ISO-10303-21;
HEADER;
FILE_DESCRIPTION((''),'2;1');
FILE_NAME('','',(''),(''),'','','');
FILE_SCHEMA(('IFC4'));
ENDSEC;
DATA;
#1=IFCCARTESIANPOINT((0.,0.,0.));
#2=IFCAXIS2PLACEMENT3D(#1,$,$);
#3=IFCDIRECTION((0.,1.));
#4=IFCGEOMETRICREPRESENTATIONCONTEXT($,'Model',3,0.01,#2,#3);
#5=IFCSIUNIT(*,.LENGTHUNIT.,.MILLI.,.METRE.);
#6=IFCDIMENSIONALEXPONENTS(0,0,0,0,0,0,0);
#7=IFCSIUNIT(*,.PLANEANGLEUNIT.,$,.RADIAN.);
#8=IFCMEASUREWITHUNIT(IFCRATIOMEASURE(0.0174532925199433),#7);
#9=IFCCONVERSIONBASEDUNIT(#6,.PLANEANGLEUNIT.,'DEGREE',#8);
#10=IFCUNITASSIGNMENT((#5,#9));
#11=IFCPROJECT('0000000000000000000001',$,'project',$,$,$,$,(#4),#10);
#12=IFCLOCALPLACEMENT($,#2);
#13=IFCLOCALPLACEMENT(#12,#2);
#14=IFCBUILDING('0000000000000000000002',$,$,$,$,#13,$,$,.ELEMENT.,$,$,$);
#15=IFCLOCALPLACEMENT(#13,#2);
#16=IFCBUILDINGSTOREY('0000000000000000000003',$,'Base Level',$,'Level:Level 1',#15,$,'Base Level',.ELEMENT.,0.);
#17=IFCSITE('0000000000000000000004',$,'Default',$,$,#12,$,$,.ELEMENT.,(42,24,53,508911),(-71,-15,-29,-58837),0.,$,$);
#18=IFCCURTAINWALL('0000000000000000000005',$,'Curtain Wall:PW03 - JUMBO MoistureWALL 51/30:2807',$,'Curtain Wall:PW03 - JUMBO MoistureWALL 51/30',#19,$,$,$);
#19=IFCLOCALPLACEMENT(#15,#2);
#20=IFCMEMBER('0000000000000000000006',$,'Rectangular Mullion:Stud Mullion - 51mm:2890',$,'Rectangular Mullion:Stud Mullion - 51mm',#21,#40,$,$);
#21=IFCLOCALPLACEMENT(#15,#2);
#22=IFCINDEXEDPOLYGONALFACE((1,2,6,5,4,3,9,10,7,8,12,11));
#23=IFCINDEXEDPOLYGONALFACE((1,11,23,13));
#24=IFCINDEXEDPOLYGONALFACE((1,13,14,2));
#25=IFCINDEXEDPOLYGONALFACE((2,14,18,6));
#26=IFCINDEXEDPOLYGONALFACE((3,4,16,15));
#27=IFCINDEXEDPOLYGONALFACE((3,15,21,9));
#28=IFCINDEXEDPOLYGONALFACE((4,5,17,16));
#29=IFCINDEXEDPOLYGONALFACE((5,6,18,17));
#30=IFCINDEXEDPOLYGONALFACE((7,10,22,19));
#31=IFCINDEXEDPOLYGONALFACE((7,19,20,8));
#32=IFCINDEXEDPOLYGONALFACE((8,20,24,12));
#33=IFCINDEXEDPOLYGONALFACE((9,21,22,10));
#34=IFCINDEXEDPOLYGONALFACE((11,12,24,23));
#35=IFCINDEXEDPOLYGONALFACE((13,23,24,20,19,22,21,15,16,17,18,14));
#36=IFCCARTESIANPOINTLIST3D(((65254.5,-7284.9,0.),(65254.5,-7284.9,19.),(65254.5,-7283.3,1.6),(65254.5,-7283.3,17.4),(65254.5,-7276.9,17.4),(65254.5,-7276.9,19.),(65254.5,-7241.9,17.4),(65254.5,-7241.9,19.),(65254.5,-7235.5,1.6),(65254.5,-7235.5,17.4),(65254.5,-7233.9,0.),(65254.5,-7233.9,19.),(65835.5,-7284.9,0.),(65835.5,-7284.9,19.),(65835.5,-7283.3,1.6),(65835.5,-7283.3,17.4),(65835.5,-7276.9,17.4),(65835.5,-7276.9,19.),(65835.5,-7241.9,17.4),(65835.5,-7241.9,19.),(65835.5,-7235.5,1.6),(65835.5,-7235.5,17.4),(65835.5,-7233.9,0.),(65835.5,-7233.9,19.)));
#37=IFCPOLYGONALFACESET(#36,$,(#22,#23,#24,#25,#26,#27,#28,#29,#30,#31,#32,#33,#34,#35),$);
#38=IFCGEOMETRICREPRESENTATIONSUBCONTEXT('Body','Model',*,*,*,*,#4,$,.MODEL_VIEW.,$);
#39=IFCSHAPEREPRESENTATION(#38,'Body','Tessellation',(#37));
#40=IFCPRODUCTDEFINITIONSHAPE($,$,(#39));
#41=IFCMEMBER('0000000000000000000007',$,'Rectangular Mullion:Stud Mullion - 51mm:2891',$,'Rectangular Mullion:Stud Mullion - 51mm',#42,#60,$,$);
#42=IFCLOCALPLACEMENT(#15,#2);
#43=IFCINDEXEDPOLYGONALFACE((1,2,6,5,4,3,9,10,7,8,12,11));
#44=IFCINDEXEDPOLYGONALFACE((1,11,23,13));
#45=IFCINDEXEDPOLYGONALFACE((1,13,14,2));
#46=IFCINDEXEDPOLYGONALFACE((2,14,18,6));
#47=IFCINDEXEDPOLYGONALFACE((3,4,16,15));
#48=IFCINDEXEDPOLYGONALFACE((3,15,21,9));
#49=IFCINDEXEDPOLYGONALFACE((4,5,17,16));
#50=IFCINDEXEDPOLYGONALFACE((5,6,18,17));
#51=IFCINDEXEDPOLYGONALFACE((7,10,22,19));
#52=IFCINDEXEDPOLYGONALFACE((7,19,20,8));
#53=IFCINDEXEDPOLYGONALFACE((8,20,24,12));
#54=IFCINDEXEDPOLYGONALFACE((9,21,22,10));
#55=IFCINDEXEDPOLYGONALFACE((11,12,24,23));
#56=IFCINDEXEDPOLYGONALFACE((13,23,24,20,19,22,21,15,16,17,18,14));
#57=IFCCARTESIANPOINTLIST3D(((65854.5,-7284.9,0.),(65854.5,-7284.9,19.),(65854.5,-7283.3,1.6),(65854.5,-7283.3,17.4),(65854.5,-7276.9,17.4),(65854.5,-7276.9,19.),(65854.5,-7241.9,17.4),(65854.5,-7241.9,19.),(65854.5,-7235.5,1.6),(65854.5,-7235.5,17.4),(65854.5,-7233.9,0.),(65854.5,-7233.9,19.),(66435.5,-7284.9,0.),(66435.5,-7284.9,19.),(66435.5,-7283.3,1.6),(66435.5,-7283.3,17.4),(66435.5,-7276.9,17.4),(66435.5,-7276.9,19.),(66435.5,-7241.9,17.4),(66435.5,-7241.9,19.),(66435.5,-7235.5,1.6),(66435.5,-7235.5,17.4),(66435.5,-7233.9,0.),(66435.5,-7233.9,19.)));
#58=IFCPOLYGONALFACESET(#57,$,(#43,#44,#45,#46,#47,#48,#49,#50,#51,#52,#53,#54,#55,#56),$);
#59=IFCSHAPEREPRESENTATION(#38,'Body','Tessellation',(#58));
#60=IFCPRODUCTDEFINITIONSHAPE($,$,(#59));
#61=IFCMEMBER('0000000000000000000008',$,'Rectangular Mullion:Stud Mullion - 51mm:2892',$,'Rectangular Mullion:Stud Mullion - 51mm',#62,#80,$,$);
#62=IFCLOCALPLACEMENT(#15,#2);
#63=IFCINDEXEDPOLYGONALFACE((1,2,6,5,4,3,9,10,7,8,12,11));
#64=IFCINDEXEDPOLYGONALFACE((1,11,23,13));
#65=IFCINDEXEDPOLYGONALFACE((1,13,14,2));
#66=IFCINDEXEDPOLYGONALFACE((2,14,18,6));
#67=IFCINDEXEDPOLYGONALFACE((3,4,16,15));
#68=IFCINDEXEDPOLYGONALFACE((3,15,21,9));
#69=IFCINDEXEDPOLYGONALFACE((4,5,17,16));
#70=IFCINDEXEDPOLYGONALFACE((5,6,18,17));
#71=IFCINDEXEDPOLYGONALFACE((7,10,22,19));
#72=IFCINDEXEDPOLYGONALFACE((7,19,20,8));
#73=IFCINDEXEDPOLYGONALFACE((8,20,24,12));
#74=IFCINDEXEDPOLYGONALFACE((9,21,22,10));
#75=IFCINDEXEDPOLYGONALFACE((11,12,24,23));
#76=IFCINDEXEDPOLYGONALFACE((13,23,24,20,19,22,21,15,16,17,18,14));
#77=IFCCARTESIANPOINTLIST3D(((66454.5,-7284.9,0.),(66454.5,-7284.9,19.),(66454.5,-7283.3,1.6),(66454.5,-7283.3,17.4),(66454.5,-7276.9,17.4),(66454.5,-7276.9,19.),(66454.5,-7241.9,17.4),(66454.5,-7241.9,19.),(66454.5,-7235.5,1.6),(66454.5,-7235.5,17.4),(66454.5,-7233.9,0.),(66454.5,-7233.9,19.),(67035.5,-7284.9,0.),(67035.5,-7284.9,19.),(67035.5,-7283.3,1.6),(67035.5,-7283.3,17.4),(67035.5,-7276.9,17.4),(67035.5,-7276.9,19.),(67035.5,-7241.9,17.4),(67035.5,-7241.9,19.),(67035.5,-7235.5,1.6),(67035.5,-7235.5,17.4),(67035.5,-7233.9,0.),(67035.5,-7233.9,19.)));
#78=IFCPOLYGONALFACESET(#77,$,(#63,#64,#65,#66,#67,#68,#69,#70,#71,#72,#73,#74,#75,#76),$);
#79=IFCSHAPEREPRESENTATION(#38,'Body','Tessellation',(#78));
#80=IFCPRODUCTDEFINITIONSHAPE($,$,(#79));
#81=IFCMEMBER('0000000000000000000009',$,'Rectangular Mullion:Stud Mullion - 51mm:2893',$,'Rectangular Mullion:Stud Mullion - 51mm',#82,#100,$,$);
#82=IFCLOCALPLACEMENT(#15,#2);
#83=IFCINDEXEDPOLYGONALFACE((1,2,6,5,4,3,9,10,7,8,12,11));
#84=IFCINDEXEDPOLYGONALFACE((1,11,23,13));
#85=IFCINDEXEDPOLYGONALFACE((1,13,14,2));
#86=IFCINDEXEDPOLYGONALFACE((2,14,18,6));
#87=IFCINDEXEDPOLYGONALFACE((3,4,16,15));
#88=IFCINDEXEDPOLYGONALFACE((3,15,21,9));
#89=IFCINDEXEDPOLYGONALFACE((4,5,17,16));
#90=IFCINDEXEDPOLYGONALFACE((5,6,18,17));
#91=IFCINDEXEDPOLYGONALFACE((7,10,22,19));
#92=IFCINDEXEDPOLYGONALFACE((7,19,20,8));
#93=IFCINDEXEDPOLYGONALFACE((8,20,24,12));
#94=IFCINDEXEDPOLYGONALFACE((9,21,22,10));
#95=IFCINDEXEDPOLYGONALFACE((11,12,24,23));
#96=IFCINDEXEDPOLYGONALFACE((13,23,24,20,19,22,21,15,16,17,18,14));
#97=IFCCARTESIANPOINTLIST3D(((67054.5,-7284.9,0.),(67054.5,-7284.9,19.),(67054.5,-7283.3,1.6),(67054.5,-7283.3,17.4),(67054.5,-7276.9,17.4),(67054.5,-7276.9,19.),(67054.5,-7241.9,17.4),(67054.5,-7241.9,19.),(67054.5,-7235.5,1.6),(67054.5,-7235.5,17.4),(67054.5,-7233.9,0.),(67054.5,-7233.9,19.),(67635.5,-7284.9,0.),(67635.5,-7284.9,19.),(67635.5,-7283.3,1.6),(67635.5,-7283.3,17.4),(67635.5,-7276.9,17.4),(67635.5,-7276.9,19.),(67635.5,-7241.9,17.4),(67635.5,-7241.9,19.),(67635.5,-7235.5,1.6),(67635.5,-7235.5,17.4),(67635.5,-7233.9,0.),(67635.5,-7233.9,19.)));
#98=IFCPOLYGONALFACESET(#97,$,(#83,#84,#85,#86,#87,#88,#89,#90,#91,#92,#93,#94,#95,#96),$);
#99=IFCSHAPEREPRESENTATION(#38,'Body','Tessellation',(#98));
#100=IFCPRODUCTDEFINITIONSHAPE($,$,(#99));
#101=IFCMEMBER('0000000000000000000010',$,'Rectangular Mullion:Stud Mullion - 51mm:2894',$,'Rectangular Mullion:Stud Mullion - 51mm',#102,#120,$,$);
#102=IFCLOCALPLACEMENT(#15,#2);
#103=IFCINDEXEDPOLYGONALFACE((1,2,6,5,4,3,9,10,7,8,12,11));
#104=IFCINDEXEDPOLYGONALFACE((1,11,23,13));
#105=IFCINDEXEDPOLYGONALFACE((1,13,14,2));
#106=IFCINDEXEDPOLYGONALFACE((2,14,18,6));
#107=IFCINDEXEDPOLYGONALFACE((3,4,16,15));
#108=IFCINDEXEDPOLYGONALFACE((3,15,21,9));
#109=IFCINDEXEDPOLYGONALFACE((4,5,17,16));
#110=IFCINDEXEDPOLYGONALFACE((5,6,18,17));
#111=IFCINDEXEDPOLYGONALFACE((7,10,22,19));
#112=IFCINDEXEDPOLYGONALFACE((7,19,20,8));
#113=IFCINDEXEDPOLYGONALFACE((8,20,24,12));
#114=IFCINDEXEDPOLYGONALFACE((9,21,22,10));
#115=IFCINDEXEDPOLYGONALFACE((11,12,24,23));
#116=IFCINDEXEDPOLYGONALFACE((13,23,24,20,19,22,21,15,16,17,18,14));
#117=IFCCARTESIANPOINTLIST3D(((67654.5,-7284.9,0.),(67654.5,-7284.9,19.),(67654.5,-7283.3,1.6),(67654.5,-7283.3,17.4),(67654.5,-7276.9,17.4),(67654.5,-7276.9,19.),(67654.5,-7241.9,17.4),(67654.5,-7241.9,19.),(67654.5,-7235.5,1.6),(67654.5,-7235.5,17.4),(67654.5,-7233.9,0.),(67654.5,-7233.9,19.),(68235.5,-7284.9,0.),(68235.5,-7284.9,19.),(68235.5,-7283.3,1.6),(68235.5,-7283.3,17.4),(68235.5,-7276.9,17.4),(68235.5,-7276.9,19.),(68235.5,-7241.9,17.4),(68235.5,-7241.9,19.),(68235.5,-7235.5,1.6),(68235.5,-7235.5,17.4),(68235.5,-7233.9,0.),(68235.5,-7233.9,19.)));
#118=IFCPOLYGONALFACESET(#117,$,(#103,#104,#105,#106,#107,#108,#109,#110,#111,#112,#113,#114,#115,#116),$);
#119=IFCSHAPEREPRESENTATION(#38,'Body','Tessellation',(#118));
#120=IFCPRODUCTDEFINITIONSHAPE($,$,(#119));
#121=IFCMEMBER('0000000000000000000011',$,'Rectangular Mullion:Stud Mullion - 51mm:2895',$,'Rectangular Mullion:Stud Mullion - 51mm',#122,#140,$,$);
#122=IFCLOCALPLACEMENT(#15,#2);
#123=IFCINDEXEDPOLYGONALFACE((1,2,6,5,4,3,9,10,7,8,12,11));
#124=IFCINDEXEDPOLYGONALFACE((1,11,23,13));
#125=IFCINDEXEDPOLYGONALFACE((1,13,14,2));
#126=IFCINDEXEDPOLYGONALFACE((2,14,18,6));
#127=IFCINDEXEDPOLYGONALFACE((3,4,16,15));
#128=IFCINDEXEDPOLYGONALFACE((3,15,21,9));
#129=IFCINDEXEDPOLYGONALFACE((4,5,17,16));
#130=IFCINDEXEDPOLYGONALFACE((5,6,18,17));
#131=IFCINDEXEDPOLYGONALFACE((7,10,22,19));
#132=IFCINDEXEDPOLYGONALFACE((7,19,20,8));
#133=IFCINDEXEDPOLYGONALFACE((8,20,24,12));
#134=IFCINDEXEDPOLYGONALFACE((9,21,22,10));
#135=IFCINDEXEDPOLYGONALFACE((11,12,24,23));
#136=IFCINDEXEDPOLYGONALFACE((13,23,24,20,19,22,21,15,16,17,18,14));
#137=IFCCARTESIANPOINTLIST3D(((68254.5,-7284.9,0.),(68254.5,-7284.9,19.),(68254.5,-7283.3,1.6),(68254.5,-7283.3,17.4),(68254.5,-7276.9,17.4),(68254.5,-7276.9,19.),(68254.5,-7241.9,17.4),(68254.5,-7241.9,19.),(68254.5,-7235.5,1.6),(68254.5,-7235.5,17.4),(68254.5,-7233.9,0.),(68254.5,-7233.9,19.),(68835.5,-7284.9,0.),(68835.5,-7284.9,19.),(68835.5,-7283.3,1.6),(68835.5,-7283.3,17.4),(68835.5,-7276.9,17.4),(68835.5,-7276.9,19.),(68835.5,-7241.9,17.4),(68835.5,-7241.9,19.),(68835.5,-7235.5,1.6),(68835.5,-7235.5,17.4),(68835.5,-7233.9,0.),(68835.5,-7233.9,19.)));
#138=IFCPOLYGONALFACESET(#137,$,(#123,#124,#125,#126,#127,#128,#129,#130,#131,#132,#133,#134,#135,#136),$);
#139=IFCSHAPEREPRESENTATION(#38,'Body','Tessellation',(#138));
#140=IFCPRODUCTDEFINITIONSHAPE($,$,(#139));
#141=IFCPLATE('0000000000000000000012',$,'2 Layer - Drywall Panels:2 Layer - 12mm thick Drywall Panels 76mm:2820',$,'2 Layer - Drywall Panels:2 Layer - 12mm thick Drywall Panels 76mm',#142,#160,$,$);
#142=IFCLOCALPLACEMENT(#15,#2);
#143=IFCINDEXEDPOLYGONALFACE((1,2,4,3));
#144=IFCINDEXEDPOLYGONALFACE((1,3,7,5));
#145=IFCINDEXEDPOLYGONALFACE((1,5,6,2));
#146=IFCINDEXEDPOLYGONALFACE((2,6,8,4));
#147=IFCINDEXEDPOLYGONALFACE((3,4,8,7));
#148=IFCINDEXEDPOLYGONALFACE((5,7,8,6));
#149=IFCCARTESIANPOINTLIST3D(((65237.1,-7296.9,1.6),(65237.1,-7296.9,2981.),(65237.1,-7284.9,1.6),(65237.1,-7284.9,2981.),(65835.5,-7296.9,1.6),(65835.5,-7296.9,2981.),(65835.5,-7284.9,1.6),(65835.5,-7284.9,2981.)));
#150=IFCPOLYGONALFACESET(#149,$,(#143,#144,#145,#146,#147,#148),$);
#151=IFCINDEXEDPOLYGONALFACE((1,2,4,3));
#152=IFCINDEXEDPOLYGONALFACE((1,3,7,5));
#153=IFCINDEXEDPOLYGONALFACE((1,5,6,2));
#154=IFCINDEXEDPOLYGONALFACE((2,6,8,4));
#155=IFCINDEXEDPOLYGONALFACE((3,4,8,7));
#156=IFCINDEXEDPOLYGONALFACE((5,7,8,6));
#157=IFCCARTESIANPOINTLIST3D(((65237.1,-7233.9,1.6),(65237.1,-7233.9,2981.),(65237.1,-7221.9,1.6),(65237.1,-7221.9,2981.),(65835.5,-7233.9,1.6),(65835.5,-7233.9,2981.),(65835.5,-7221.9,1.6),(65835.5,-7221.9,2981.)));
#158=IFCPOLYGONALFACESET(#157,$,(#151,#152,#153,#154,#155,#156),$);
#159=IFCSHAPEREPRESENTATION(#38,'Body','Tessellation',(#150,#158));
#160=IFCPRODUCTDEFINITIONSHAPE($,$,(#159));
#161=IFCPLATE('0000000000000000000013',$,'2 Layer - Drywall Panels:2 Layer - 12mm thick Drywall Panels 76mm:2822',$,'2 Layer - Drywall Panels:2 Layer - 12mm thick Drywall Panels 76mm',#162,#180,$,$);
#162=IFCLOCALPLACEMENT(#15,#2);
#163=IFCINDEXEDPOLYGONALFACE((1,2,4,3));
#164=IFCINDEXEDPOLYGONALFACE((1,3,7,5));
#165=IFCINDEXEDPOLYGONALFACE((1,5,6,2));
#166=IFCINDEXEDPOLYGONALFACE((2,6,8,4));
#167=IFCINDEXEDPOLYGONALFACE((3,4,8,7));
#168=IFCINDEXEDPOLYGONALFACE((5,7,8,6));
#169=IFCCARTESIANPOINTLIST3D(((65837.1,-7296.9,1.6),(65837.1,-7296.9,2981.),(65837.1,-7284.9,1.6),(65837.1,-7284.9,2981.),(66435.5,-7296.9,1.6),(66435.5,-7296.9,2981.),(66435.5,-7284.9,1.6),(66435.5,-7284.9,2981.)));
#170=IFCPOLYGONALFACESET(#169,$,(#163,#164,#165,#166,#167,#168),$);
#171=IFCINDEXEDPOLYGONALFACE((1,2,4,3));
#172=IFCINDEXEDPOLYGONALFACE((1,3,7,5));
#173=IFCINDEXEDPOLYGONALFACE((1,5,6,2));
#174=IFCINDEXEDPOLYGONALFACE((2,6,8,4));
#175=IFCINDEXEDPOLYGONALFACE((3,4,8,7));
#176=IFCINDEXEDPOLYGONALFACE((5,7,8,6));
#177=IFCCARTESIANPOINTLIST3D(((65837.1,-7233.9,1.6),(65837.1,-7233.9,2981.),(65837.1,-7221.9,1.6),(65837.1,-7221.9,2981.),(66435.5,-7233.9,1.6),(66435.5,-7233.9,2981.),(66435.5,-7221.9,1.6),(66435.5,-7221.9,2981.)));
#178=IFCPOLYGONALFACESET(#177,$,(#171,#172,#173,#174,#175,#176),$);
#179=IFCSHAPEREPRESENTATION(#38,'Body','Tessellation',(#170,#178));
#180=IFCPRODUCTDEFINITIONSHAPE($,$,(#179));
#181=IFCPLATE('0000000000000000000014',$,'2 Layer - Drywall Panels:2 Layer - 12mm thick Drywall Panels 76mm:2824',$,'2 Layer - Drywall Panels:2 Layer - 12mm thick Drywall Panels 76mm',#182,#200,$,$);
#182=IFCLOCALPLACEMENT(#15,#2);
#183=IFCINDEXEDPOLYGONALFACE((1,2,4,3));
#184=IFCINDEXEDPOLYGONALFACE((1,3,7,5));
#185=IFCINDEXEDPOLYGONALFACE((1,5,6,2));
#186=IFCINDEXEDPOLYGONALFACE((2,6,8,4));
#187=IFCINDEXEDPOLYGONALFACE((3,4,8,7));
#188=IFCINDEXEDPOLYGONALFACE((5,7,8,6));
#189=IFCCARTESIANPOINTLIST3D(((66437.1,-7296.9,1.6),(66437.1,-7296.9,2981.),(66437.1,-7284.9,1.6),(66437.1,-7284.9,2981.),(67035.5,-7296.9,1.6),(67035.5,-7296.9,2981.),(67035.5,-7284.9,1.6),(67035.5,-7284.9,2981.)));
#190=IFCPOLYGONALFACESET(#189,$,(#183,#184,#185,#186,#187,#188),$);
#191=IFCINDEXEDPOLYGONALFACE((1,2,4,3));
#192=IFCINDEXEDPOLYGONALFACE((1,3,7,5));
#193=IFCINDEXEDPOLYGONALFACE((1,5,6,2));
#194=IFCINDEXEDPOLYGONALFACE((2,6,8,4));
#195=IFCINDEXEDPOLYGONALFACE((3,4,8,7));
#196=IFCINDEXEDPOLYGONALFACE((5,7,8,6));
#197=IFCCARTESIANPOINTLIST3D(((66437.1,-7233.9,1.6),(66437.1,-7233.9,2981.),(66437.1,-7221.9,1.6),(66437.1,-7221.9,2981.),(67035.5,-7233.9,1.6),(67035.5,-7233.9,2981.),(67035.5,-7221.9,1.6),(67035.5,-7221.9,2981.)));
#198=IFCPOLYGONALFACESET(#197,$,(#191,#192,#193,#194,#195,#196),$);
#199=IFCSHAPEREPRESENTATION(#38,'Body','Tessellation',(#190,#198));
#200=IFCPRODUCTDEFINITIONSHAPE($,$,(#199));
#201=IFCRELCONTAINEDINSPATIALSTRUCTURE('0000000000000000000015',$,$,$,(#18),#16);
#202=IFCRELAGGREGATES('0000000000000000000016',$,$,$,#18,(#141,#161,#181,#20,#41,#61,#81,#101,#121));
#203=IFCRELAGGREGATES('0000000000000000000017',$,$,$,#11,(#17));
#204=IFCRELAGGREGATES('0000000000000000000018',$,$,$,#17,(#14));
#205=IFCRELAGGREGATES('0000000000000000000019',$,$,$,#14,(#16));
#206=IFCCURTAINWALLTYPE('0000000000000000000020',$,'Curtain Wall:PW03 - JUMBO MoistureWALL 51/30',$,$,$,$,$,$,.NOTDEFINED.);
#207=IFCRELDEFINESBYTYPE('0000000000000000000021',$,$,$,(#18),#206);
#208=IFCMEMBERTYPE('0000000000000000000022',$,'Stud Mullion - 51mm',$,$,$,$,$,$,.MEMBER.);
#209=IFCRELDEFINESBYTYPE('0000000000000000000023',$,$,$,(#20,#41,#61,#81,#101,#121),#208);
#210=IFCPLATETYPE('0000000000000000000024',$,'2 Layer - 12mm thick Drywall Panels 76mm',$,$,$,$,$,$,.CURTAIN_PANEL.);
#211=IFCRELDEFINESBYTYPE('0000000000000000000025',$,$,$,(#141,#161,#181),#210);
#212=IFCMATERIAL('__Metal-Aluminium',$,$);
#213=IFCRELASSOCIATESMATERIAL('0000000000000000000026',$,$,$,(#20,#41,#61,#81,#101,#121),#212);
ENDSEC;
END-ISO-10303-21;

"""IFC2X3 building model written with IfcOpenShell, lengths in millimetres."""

from ifc_helpers import new_model, entity, si_unit, converted_unit, direction, frame, frame_2d, origin, origin_2d_with_axis, place, context, subcontext, project, spatial, polyline, rectangle, outline, extrude, source, transform, mapped, material, type_object, type_shapes, element, aggregate, save


model = new_model("IFC2X3")

# Units and contexts
model_context = context("Model", 3, precision=0.01, world=origin(), true_north=direction((0.0, 1.0)))
body_context = subcontext(model_context, "Body", "Model", "MODEL_VIEW")
ifc_project = project(units=[si_unit("LENGTHUNIT", "METRE", prefix="MILLI"), converted_unit("PLANEANGLEUNIT", "DEGREE", entity("IfcRatioMeasure", 0.0174532925199433), si_unit("PLANEANGLEUNIT", "RADIAN"), dimensions=[0, 0, 0, 0, 0, 0, 0])], contexts=[model_context])

# Site, building, storey
site_placement = place(None, origin())
site = spatial("IfcSite", under=ifc_project, at=site_placement, Name="Default", CompositionType="ELEMENT", RefLatitude=(42, 24, 53, 508911), RefLongitude=(-71, -15, -29, -58837), RefElevation=0.0)
building_placement = place(site_placement, origin())
building = spatial("IfcBuilding", under=site, at=building_placement, CompositionType="ELEMENT")
storey_placement = place(building_placement, origin())
storey = spatial("IfcBuildingStorey", under=building, at=storey_placement, Name="Base Level", ObjectType="Level:Level 1", LongName="Base Level", CompositionType="ELEMENT", Elevation=0.0)

# Curtain wall, members, plates
curtain_wall_type = type_object("IfcCurtainWallType", Name="Curtain Wall:PW03 - JUMBO MoistureWALL 51/30", PredefinedType="NOTDEFINED")
curtain_wall_placement = place(building_placement, origin())
curtain_wall = element("IfcCurtainWall", 1, at=curtain_wall_placement, inside=storey, type_object=curtain_wall_type, Name="Curtain Wall:PW03 - JUMBO MoistureWALL 51/30:2807", ObjectType="Curtain Wall:PW03 - JUMBO MoistureWALL 51/30")
ifc_material = material(Name="__Metal-Aluminium")
member_type_1 = type_object("IfcMemberType", Name="Stud Mullion - 51mm", PredefinedType="MEMBER")
shared_shape_1 = source(origin(), body_context, "Body", "SweptSolid", [
    extrude(outline(polyline([(17.5, -6.6), (25.5, -6.6), (25.5, 12.4), (-25.5, 12.4), (-25.5, -6.6), (-17.5, -6.6), (-17.5, -5.0), (-23.9, -5.0), (-23.9, 10.8), (23.9, 10.8), (23.9, -5.0), (17.5, -5.0), (17.5, -6.6)])), frame((-12.4, 0.0, -581.0), z_axis=(0.0, 0.0, 1.0), x_axis=(0.0, -1.0, 0.0)), (0.0, 0.0, 1.0), 581.0),
])
type_shapes(member_type_1, [shared_shape_1])
member_1_placement = place(building_placement, frame((65254.5, -7259.4, 0.0), z_axis=(-1.0, 0.0, 0.0), x_axis=(0.0, 0.0, -1.0)))
member_1 = element("IfcMember", 2, at=member_1_placement, type_object=member_type_1, material=ifc_material, Name="Rectangular Mullion:Stud Mullion - 51mm:2890", ObjectType="Rectangular Mullion:Stud Mullion - 51mm", context=body_context, shape_type="MappedRepresentation", body=[
    mapped(shared_shape_1, transform((0.0, 0.0, 0.0), scale=1.0)),
])
member_2_placement = place(building_placement, frame((65854.5, -7259.4, 0.0), z_axis=(-1.0, 0.0, 0.0), x_axis=(0.0, 0.0, -1.0)))
member_2 = element("IfcMember", 3, at=member_2_placement, type_object=member_type_1, material=ifc_material, Name="Rectangular Mullion:Stud Mullion - 51mm:2891", ObjectType="Rectangular Mullion:Stud Mullion - 51mm", context=body_context, shape_type="MappedRepresentation", body=[
    mapped(shared_shape_1, transform((0.0, 0.0, 0.0), scale=1.0)),
])
member_3_placement = place(building_placement, frame((66454.5, -7259.4, 0.0), z_axis=(-1.0, 0.0, 0.0), x_axis=(0.0, 0.0, -1.0)))
member_3 = element("IfcMember", 4, at=member_3_placement, type_object=member_type_1, material=ifc_material, Name="Rectangular Mullion:Stud Mullion - 51mm:2892", ObjectType="Rectangular Mullion:Stud Mullion - 51mm", context=body_context, shape_type="MappedRepresentation", body=[
    mapped(shared_shape_1, transform((0.0, 0.0, 0.0), scale=1.0)),
])
member_4_placement = place(building_placement, frame((67054.5, -7259.4, 0.0), z_axis=(-1.0, 0.0, 0.0), x_axis=(0.0, 0.0, -1.0)))
member_4 = element("IfcMember", 5, at=member_4_placement, type_object=member_type_1, material=ifc_material, Name="Rectangular Mullion:Stud Mullion - 51mm:2893", ObjectType="Rectangular Mullion:Stud Mullion - 51mm", context=body_context, shape_type="MappedRepresentation", body=[
    mapped(shared_shape_1, transform((0.0, 0.0, 0.0), scale=1.0)),
])
member_5_placement = place(building_placement, frame((67654.5, -7259.4, 0.0), z_axis=(-1.0, 0.0, 0.0), x_axis=(0.0, 0.0, -1.0)))
member_5 = element("IfcMember", 6, at=member_5_placement, type_object=member_type_1, material=ifc_material, Name="Rectangular Mullion:Stud Mullion - 51mm:2894", ObjectType="Rectangular Mullion:Stud Mullion - 51mm", context=body_context, shape_type="MappedRepresentation", body=[
    mapped(shared_shape_1, transform((0.0, 0.0, 0.0), scale=1.0)),
])
member_6_placement = place(building_placement, frame((68254.5, -7259.4, 0.0), z_axis=(-1.0, 0.0, 0.0), x_axis=(0.0, 0.0, -1.0)))
member_6 = element("IfcMember", 7, at=member_6_placement, type_object=member_type_1, material=ifc_material, Name="Rectangular Mullion:Stud Mullion - 51mm:2895", ObjectType="Rectangular Mullion:Stud Mullion - 51mm", context=body_context, shape_type="MappedRepresentation", body=[
    mapped(shared_shape_1, transform((0.0, 0.0, 0.0), scale=1.0)),
])
plate_type = type_object("IfcPlateType", Name="2 Layer - 12mm thick Drywall Panels 76mm", PredefinedType="CURTAIN_PANEL")
shared_shape_2 = source(origin(), body_context, "Body", "SweptSolid", [
    extrude(rectangle(XDim=598.4, YDim=12.0, at=origin_2d_with_axis()), frame((0.0, -31.5, 0.0), z_axis=(0.0, 0.0, 1.0), x_axis=(-1.0, 0.0, 0.0)), (0.0, 0.0, 1.0), 2979.4),
    extrude(rectangle(XDim=12.0, YDim=598.4, at=frame_2d((0.0, 0.0), x_axis=(1.0, 0.0))), frame((0.0, 31.5, 0.0), z_axis=(0.0, 0.0, 1.0), x_axis=(0.0, 1.0, 0.0)), (0.0, 0.0, 1.0), 2979.4),
])
type_shapes(plate_type, [shared_shape_2])
plate_1_placement = place(curtain_wall_placement, frame((65536.3, -7259.4, 1.6)))
plate_1 = element("IfcPlate", 8, at=plate_1_placement, type_object=plate_type, Name="2 Layer - Drywall Panels:2 Layer - 12mm thick Drywall Panels 76mm:2820", ObjectType="2 Layer - Drywall Panels:2 Layer - 12mm thick Drywall Panels 76mm", context=body_context, shape_type="MappedRepresentation", body=[
    mapped(shared_shape_2, transform((0.0, 0.0, 0.0), scale=1.0)),
])
plate_2_placement = place(curtain_wall_placement, frame((66136.3, -7259.4, 1.6)))
plate_2 = element("IfcPlate", 9, at=plate_2_placement, type_object=plate_type, Name="2 Layer - Drywall Panels:2 Layer - 12mm thick Drywall Panels 76mm:2822", ObjectType="2 Layer - Drywall Panels:2 Layer - 12mm thick Drywall Panels 76mm", context=body_context, shape_type="MappedRepresentation", body=[
    mapped(shared_shape_2, transform((0.0, 0.0, 0.0), scale=1.0)),
])
plate_3_placement = place(curtain_wall_placement, frame((66736.3, -7259.4, 1.6)))
plate_3 = element("IfcPlate", 10, at=plate_3_placement, type_object=plate_type, Name="2 Layer - Drywall Panels:2 Layer - 12mm thick Drywall Panels 76mm:2824", ObjectType="2 Layer - Drywall Panels:2 Layer - 12mm thick Drywall Panels 76mm", context=body_context, shape_type="MappedRepresentation", body=[
    mapped(shared_shape_2, transform((0.0, 0.0, 0.0), scale=1.0)),
])
aggregate(curtain_wall, [plate_1, plate_2, plate_3, member_1, member_2, member_3, member_4, member_5, member_6])

save(model, "model.ifc")
